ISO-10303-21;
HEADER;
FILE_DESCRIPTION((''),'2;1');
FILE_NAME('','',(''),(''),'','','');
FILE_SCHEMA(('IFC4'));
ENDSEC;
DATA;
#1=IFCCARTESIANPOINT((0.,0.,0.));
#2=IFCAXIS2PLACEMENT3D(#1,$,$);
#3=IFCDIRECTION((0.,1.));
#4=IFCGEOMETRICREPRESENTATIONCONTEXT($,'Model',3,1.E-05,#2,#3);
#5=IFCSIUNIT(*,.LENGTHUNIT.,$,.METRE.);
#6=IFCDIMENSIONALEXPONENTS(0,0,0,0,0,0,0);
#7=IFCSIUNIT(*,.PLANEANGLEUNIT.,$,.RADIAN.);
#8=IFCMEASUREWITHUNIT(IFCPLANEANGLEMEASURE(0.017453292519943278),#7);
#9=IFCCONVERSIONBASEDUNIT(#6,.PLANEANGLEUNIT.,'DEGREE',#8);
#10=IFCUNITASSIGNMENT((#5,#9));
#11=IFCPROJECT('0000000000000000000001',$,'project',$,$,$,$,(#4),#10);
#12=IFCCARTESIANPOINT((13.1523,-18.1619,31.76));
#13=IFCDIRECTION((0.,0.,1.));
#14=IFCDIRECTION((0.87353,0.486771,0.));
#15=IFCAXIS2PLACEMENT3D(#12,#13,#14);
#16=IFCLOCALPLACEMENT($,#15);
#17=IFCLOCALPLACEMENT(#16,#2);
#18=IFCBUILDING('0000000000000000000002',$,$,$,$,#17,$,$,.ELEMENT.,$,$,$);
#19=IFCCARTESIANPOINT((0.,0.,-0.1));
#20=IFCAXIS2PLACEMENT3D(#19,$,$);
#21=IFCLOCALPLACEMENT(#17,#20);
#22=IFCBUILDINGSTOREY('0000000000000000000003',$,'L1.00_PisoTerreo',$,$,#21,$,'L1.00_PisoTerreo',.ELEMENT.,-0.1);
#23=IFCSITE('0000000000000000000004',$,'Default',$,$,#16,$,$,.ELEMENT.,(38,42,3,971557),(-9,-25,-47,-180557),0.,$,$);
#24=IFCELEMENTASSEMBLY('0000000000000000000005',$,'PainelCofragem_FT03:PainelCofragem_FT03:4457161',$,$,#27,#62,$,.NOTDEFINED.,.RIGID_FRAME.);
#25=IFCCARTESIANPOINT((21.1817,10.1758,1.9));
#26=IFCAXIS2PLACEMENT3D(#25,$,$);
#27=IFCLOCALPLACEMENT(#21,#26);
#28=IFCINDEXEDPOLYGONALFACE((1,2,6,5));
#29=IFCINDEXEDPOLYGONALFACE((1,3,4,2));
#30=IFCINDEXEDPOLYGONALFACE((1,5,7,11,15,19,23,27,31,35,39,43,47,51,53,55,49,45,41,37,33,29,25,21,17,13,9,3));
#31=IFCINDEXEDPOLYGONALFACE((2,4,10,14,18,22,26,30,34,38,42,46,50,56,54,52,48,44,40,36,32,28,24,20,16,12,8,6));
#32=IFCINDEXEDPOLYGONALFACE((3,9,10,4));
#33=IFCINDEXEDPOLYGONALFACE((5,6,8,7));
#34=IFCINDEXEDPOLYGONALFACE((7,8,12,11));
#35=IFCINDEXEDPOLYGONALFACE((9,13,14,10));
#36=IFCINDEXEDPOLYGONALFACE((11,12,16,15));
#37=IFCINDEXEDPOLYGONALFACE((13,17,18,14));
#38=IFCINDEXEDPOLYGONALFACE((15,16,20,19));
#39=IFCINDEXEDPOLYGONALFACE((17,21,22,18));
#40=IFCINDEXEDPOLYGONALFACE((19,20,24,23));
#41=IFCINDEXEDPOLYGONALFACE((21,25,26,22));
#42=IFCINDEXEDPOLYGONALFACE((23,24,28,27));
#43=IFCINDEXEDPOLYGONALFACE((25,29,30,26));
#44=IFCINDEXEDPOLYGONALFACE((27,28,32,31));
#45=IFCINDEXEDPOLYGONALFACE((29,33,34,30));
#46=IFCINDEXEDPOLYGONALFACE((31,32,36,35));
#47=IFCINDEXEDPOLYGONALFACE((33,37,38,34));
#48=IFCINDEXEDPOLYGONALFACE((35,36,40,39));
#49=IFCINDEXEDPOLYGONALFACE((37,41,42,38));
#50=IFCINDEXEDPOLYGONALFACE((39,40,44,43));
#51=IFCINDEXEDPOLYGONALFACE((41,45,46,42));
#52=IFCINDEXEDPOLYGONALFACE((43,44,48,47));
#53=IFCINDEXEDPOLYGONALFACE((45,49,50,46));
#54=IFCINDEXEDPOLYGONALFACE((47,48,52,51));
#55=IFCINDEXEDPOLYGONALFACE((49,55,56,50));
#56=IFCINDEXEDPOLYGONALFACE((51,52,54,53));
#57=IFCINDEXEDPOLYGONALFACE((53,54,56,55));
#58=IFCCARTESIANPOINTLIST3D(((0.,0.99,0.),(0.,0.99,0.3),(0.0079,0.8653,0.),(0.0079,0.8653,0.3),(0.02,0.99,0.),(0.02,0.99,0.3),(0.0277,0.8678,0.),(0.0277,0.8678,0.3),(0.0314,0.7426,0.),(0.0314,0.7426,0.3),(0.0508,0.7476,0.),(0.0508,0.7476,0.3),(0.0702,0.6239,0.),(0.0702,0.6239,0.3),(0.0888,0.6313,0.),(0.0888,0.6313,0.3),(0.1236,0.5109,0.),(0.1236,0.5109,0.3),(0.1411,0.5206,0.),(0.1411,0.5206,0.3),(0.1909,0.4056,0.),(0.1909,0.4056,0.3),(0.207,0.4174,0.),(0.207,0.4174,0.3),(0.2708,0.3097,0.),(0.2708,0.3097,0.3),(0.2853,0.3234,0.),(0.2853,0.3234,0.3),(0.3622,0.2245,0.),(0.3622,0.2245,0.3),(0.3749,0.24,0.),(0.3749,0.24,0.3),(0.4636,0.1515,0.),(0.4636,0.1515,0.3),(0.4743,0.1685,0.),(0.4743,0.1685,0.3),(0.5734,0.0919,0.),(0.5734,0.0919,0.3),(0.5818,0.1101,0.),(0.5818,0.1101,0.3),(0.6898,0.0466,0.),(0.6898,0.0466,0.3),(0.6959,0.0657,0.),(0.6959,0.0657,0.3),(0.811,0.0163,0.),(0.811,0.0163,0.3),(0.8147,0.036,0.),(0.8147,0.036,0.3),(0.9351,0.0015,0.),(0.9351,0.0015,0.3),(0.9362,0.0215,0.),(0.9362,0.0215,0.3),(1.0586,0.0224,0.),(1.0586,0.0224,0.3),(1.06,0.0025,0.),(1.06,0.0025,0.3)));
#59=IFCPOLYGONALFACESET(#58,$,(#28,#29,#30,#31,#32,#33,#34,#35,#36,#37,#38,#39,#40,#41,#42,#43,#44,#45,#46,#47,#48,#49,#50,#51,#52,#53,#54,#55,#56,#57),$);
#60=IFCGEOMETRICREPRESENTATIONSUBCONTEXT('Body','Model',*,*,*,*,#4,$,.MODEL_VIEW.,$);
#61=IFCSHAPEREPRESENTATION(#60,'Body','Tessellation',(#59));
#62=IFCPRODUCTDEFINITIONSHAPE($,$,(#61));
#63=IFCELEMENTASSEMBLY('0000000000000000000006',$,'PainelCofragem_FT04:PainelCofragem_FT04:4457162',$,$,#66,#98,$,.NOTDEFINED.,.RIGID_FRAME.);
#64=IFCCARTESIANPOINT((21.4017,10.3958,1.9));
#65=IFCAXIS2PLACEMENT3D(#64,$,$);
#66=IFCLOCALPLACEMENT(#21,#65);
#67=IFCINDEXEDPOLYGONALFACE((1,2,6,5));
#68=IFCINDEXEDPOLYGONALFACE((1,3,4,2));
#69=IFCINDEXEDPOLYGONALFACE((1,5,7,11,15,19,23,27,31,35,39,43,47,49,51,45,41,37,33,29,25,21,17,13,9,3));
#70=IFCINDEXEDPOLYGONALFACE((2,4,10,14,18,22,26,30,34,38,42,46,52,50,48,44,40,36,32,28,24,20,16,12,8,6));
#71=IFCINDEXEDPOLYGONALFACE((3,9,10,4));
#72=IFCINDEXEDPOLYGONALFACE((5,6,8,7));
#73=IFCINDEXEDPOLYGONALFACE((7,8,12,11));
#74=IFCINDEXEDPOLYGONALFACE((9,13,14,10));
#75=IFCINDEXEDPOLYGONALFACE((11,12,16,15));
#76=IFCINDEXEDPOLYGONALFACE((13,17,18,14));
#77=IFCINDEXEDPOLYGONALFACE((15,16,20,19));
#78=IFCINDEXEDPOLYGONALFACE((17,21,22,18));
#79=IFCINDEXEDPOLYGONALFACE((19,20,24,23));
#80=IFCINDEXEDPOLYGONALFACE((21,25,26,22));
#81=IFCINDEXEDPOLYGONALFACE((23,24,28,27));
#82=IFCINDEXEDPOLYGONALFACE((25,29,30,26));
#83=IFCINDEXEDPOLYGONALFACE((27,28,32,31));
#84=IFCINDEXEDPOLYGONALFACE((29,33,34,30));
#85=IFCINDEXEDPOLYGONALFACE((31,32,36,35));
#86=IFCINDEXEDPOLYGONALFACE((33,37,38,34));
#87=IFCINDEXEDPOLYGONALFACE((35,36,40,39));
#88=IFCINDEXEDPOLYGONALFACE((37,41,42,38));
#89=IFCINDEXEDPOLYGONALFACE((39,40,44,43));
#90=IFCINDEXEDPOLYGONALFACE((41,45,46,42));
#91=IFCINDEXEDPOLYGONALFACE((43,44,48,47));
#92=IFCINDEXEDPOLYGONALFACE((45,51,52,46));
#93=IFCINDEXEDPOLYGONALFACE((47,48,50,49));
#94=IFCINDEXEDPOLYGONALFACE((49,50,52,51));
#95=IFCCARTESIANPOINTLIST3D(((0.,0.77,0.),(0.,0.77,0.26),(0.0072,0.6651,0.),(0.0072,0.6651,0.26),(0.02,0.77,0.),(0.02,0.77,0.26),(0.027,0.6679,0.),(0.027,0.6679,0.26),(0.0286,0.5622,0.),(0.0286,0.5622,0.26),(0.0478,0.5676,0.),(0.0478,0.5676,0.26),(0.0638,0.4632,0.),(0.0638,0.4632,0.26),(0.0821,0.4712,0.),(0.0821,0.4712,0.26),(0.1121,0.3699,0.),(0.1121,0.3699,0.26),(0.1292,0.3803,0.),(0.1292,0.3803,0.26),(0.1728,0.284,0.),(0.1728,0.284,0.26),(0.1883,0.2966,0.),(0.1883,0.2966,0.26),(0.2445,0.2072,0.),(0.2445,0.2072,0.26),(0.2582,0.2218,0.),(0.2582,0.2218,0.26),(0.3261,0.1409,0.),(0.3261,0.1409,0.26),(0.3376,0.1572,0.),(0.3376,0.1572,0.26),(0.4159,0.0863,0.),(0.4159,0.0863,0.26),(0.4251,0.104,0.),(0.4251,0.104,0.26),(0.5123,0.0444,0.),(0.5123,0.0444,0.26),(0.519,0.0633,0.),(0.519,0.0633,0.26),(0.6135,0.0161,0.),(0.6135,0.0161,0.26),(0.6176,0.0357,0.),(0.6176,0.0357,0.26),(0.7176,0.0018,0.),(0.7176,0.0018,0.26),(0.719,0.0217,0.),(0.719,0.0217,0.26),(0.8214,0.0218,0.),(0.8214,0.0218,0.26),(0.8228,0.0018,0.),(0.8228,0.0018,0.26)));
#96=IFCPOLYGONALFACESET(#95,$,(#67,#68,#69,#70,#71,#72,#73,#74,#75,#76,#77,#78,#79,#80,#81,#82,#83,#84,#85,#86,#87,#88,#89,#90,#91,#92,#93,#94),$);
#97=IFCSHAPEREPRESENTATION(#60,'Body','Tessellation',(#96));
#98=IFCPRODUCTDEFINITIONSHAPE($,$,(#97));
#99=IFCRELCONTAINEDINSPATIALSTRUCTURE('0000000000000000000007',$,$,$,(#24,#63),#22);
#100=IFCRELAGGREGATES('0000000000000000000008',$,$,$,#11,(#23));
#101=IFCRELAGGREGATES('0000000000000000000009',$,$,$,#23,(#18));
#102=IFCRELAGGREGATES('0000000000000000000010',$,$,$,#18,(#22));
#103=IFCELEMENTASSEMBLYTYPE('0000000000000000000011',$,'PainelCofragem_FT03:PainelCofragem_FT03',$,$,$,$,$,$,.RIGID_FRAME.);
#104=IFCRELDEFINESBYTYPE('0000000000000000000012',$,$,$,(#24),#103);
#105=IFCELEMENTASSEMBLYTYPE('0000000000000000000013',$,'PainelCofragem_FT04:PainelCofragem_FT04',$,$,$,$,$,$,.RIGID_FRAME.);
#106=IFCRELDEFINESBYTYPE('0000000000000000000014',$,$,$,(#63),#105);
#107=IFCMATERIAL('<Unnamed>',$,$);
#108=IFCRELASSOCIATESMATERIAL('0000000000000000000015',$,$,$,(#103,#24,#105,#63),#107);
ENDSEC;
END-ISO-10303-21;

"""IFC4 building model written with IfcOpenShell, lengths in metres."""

from ifc_helpers import new_model, entity, si_unit, converted_unit, direction, frame, origin, place, context, subcontext, project, spatial, line, arc, indexed_curve, outline, extrude, source, transform, mapped, material, type_object, type_shapes, element, save


model = new_model("IFC4")

# Units and contexts
model_context = context("Model", 3, precision=1e-05, world=origin(), true_north=direction((0.0, 1.0)))
body_context = subcontext(model_context, "Body", "Model", "MODEL_VIEW")
ifc_project = project(units=[si_unit("LENGTHUNIT", "METRE"), converted_unit("PLANEANGLEUNIT", "DEGREE", entity("IfcPlaneAngleMeasure", 0.017453292519943278), si_unit("PLANEANGLEUNIT", "RADIAN"), dimensions=[0, 0, 0, 0, 0, 0, 0])], contexts=[model_context])

# Site, building, storey
site_placement = place(None, frame((13.1523, -18.1619, 31.76), z_axis=(0.0, 0.0, 1.0), x_axis=(0.87353, 0.486771, 0.0)))
site = spatial("IfcSite", under=ifc_project, at=site_placement, Name="Default", CompositionType="ELEMENT", RefLatitude=(38, 42, 3, 971557), RefLongitude=(-9, -25, -47, -180557), RefElevation=0.0)
building_placement = place(site_placement, origin())
building = spatial("IfcBuilding", under=site, at=building_placement, CompositionType="ELEMENT")
storey_placement = place(building_placement, frame((0.0, 0.0, -0.1)))
storey = spatial("IfcBuildingStorey", under=building, at=storey_placement, Name="L1.00_PisoTerreo", LongName="L1.00_PisoTerreo", CompositionType="ELEMENT", Elevation=-0.1)

# Element assemblies
ifc_material_1 = material(Name="<Unnamed>")
element_assembly_type_1 = type_object("IfcElementAssemblyType", Name="PainelCofragem_FT03:PainelCofragem_FT03", PredefinedType="RIGID_FRAME", material=ifc_material_1)
shared_shape_1 = source(origin(), body_context, "Body", "SweptSolid", [
    extrude(outline(indexed_curve([(0.5147, 0.4888), (0.2059, -0.221), (-0.524, -0.4788), (-0.5254, -0.4987), (0.2195, -0.2356), (0.5347, 0.4888)], segments=[arc(1, 2, 3), line(3, 4), arc(4, 5, 6), line(6, 1)], self_intersect=False)), frame((0.5347, 0.5012, 0.0), z_axis=(0.0, 0.0, -1.0), x_axis=(-1.0, 0.0, 0.0)), (0.0, 0.0, -1.0), 0.3),
])
type_shapes(element_assembly_type_1, [shared_shape_1])
assembly_1_placement = place(storey_placement, frame((21.1817, 10.1758, 1.9)))
element("IfcElementAssembly", 1, at=assembly_1_placement, inside=storey, type_object=element_assembly_type_1, material=ifc_material_1, Name="PainelCofragem_FT03:PainelCofragem_FT03:4457161", AssemblyPlace="NOTDEFINED", PredefinedType="RIGID_FRAME", context=body_context, shape_type="MappedRepresentation", body=[
    mapped(shared_shape_1, transform((0.0, 0.0, 0.0), scale=1.0)),
])
element_assembly_type_2 = type_object("IfcElementAssemblyType", Name="PainelCofragem_FT04:PainelCofragem_FT04", PredefinedType="RIGID_FRAME", material=ifc_material_1)
shared_shape_2 = source(origin(), body_context, "Body", "SweptSolid", [
    extrude(outline(indexed_curve([(-0.416, 0.3791), (-0.1715, -0.1837), (0.4067, -0.3891), (0.4054, -0.3691), (-0.1579, -0.1691), (-0.396, 0.3791)], segments=[arc(1, 2, 3), line(3, 4), arc(4, 5, 6), line(6, 1)], self_intersect=False)), frame((0.416, 0.3909, 0.0), z_axis=(0.0, 0.0, -1.0), x_axis=(-0.068516, 0.99765, 0.0)), (0.0, 0.0, -1.0), 0.26),
])
type_shapes(element_assembly_type_2, [shared_shape_2])
assembly_2_placement = place(storey_placement, frame((21.4017, 10.3958, 1.9)))
element("IfcElementAssembly", 2, at=assembly_2_placement, inside=storey, type_object=element_assembly_type_2, material=ifc_material_1, Name="PainelCofragem_FT04:PainelCofragem_FT04:4457162", AssemblyPlace="NOTDEFINED", PredefinedType="RIGID_FRAME", context=body_context, shape_type="MappedRepresentation", body=[
    mapped(shared_shape_2, transform((0.0, 0.0, 0.0), scale=1.0)),
])

save(model, "model.ifc")
